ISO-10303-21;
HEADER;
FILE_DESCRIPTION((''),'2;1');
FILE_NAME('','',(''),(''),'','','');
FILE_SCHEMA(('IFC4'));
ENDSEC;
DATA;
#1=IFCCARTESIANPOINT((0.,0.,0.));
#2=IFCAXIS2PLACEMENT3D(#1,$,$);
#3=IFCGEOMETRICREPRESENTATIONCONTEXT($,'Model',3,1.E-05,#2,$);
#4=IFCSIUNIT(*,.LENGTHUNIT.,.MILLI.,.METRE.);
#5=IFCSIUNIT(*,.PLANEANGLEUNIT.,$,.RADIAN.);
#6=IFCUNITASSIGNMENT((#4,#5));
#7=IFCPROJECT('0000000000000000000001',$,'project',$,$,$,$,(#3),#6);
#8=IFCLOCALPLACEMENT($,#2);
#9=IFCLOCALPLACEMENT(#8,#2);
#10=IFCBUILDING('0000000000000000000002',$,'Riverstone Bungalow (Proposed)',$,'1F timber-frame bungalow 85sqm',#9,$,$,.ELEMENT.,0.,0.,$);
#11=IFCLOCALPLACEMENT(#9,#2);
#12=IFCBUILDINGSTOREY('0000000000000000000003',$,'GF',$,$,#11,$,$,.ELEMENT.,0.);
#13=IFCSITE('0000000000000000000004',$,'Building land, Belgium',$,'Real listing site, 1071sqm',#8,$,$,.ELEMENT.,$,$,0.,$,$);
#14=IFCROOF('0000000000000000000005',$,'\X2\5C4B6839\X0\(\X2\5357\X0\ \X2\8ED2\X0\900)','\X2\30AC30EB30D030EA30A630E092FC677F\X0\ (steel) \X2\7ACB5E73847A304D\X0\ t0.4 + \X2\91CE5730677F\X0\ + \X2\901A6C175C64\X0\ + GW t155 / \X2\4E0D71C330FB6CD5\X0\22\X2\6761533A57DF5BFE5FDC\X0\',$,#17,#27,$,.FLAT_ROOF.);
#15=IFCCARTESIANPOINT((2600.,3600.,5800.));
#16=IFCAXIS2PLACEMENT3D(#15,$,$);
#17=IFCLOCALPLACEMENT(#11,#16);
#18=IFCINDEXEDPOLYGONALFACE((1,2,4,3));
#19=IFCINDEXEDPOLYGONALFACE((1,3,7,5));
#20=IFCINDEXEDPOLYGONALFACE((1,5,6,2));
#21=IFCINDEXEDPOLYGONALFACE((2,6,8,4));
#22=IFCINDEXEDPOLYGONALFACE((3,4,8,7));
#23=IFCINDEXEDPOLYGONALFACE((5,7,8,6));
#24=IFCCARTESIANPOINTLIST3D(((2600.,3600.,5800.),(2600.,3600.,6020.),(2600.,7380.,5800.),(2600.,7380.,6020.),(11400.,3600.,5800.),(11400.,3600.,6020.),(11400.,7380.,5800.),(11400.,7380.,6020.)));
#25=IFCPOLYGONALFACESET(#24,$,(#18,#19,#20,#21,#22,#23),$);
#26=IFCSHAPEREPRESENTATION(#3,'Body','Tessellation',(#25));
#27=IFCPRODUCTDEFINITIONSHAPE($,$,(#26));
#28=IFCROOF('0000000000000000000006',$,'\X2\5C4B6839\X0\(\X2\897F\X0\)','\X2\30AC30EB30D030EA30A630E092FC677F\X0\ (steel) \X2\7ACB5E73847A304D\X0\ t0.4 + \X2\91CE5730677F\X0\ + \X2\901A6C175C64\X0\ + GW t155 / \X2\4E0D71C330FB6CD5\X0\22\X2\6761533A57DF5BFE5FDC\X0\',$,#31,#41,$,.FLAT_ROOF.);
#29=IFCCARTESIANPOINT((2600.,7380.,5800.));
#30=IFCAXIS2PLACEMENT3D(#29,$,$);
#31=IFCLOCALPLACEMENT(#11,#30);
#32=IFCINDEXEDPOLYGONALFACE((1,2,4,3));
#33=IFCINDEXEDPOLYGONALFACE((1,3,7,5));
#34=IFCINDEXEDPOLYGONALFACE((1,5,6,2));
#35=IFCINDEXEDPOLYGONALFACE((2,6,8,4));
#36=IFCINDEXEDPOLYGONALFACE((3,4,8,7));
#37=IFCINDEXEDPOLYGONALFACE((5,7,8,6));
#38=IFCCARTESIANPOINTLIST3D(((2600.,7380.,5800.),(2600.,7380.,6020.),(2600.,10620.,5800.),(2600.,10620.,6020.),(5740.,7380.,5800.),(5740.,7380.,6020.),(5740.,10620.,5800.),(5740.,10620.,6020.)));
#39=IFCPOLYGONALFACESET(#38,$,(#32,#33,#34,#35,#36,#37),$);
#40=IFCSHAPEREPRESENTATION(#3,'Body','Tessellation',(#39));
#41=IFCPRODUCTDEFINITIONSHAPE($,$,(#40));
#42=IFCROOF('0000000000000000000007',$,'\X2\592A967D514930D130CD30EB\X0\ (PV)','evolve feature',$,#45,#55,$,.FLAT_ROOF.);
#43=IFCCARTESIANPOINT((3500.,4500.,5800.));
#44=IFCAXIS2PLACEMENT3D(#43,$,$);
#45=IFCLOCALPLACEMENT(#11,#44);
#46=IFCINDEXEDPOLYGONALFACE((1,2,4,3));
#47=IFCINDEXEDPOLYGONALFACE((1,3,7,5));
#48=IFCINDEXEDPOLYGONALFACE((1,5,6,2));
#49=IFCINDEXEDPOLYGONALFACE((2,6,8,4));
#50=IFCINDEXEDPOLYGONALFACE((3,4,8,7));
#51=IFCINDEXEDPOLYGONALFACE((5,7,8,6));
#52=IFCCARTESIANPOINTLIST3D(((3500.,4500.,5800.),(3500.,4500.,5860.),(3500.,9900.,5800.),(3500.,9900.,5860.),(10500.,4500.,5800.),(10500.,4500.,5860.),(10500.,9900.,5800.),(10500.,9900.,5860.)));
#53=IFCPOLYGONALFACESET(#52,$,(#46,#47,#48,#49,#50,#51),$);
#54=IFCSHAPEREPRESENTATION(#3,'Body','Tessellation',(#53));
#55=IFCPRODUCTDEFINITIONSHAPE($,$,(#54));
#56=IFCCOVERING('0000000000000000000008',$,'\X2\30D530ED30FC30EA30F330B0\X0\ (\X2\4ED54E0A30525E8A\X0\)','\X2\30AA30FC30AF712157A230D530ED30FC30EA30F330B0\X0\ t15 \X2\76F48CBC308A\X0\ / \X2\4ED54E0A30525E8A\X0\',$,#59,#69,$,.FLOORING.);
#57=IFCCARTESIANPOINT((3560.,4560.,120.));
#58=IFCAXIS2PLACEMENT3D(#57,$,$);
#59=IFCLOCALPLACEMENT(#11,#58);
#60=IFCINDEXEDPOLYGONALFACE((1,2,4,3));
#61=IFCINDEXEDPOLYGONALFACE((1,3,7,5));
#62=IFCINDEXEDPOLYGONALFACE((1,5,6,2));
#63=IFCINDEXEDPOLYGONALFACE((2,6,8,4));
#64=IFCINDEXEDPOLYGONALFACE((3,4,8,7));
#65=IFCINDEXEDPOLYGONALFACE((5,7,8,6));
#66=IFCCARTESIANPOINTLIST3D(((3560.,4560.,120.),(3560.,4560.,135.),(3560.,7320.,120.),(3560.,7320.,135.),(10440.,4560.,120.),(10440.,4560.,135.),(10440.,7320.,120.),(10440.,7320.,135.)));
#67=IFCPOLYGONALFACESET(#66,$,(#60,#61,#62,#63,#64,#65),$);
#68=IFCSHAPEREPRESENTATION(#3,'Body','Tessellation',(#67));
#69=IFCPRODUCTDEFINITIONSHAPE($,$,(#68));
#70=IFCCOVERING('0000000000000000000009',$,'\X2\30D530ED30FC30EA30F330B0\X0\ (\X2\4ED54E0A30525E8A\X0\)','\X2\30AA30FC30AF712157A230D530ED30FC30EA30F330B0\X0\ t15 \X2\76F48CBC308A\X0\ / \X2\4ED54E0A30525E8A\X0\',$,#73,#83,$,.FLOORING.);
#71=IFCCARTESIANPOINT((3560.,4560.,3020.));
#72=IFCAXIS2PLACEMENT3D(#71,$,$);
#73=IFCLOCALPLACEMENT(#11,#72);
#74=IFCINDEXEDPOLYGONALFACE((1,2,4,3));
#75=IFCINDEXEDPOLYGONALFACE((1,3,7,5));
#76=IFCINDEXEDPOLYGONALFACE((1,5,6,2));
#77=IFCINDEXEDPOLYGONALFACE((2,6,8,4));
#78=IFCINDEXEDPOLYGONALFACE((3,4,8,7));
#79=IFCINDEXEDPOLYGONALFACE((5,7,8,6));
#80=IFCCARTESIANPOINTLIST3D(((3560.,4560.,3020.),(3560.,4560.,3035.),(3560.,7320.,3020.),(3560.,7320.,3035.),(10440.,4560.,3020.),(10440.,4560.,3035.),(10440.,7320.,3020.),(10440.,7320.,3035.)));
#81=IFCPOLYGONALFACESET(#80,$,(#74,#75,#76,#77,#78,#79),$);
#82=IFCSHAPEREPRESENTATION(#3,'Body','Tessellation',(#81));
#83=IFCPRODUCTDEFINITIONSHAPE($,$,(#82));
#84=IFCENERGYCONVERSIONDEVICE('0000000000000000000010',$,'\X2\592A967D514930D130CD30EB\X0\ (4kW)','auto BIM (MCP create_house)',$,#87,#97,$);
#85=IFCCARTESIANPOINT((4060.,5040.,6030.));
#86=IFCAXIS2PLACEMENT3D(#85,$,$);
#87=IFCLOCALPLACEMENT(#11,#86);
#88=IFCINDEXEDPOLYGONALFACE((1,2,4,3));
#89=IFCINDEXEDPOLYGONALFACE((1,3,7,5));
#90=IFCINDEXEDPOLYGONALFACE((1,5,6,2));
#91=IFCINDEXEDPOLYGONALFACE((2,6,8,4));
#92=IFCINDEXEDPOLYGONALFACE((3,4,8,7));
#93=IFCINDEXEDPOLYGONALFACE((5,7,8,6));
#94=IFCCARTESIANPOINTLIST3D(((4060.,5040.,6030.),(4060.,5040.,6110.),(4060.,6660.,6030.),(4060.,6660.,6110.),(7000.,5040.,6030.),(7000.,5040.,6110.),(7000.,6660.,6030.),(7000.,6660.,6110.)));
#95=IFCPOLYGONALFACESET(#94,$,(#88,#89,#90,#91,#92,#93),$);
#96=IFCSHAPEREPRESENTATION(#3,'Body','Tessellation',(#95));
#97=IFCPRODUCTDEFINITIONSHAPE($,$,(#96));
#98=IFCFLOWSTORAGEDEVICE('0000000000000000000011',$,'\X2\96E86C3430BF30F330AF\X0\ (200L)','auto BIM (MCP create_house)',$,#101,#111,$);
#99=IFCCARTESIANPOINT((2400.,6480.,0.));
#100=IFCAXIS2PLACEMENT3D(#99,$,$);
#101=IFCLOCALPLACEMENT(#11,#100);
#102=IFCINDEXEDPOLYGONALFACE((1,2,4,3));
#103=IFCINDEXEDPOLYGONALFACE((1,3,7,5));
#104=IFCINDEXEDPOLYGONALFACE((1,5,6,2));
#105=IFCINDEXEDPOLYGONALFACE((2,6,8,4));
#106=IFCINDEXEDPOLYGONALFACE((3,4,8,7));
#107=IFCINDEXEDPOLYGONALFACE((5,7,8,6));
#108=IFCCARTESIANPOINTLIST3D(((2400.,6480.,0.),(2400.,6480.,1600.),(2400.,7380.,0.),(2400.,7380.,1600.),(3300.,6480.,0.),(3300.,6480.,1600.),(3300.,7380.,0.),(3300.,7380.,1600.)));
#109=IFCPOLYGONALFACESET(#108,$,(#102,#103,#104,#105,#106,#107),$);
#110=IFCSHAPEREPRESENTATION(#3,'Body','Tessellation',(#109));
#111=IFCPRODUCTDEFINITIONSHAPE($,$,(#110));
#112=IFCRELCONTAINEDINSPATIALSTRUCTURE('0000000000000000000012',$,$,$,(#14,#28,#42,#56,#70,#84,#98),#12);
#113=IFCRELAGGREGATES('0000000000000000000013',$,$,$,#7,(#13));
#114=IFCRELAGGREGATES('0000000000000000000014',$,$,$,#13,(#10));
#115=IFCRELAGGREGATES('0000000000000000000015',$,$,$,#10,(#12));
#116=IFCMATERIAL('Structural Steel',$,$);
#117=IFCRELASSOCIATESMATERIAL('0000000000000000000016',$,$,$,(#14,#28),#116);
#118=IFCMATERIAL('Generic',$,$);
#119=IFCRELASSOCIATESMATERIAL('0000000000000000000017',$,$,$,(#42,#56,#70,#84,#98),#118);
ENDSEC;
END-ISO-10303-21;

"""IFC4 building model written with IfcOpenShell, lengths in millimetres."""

from ifc_helpers import new_model, si_unit, frame, frame_2d, origin, place, context, project, spatial, rectangle, extrude, material, element, save


model = new_model("IFC4")

# Units and contexts
model_context = context("Model", 3, precision=1e-05, world=origin())
ifc_project = project(units=[si_unit("LENGTHUNIT", "METRE", prefix="MILLI"), si_unit("PLANEANGLEUNIT", "RADIAN")], contexts=[model_context])

# Site, building, storey
site_placement = place(None, origin())
site = spatial("IfcSite", under=ifc_project, at=site_placement, Name="Building land, Belgium", ObjectType="Real listing site, 1071sqm", CompositionType="ELEMENT", RefElevation=0.0)
building_placement = place(site_placement, origin())
building = spatial("IfcBuilding", under=site, at=building_placement, Name="Riverstone Bungalow (Proposed)", ObjectType="1F timber-frame bungalow 85sqm", CompositionType="ELEMENT", ElevationOfRefHeight=0.0, ElevationOfTerrain=0.0)
storey_placement = place(building_placement, origin())
storey = spatial("IfcBuildingStorey", under=building, at=storey_placement, Name="GF", CompositionType="ELEMENT", Elevation=0.0)

# Shared definitions
ifc_material_1 = material(Name="Generic")

# Roofs
ifc_material_2 = material(Name="Structural Steel")
roof_1_placement = place(storey_placement, frame((2600.0, 3600.0, 5800.0)))
element("IfcRoof", 1, at=roof_1_placement, inside=storey, material=ifc_material_2, Name="屋根(南 軒900)", Description="ガルバリウム鋼板 (steel) 立平葺き t0.4 + 野地板 + 通気層 + GW t155 / 不燃・法22条区域対応", PredefinedType="FLAT_ROOF", context=model_context, shape_type="SweptSolid", body=[
    extrude(rectangle(XDim=8800.0, YDim=3780.0, at=frame_2d((4400.0, 1890.0))), frame((2600.0, 3600.0, 5800.0)), (0.0, 0.0, 1.0), 220.0),
])
roof_2_placement = place(storey_placement, frame((2600.0, 7380.0, 5800.0)))
element("IfcRoof", 2, at=roof_2_placement, inside=storey, material=ifc_material_2, Name="屋根(西)", Description="ガルバリウム鋼板 (steel) 立平葺き t0.4 + 野地板 + 通気層 + GW t155 / 不燃・法22条区域対応", PredefinedType="FLAT_ROOF", context=model_context, shape_type="SweptSolid", body=[
    extrude(rectangle(XDim=3140.0, YDim=3240.0, at=frame_2d((1570.0, 1620.0))), frame((2600.0, 7380.0, 5800.0)), (0.0, 0.0, 1.0), 220.0),
])
roof_3_placement = place(storey_placement, frame((3500.0, 4500.0, 5800.0)))
element("IfcRoof", 3, at=roof_3_placement, inside=storey, material=ifc_material_1, Name="太陽光パネル (PV)", Description="evolve feature", PredefinedType="FLAT_ROOF", context=model_context, shape_type="SweptSolid", body=[
    extrude(rectangle(XDim=7000.0, YDim=5400.0, at=frame_2d((3500.0, 2700.0))), frame((3500.0, 4500.0, 5800.0)), (0.0, 0.0, 1.0), 60.0),
])

# Coverings
covering_1_placement = place(storey_placement, frame((3560.0, 4560.0, 120.0)))
element("IfcCovering", 4, at=covering_1_placement, inside=storey, material=ifc_material_1, Name="フローリング (仕上げ床)", Description="オーク無垢フローリング t15 直貼り / 仕上げ床", PredefinedType="FLOORING", context=model_context, shape_type="SweptSolid", body=[
    extrude(rectangle(XDim=6880.0, YDim=2760.0, at=frame_2d((3440.0, 1380.0))), frame((3560.0, 4560.0, 120.0)), (0.0, 0.0, 1.0), 15.0),
])
covering_2_placement = place(storey_placement, frame((3560.0, 4560.0, 3020.0)))
element("IfcCovering", 5, at=covering_2_placement, inside=storey, material=ifc_material_1, Name="フローリング (仕上げ床)", Description="オーク無垢フローリング t15 直貼り / 仕上げ床", PredefinedType="FLOORING", context=model_context, shape_type="SweptSolid", body=[
    extrude(rectangle(XDim=6880.0, YDim=2760.0, at=frame_2d((3440.0, 1380.0))), frame((3560.0, 4560.0, 3020.0)), (0.0, 0.0, 1.0), 15.0),
])

# Energy conversion device
energy_conversion_device_placement = place(storey_placement, frame((4060.0, 5040.0, 6030.0)))
element("IfcEnergyConversionDevice", 6, at=energy_conversion_device_placement, inside=storey, material=ifc_material_1, Name="太陽光パネル (4kW)", Description="auto BIM (MCP create_house)", context=model_context, shape_type="SweptSolid", body=[
    extrude(rectangle(XDim=2940.0, YDim=1620.0, at=frame_2d((1470.0, 810.0))), frame((4060.0, 5040.0, 6030.0)), (0.0, 0.0, 1.0), 80.0),
])

# Flow storage device
flow_storage_device_placement = place(storey_placement, frame((2400.0, 6480.0, 0.0)))
element("IfcFlowStorageDevice", 7, at=flow_storage_device_placement, inside=storey, material=ifc_material_1, Name="雨水タンク (200L)", Description="auto BIM (MCP create_house)", context=model_context, shape_type="SweptSolid", body=[
    extrude(rectangle(XDim=900.0, YDim=900.0, at=frame_2d((450.0, 450.0))), frame((2400.0, 6480.0, 0.0)), (0.0, 0.0, 1.0), 1600.0),
])

save(model, "model.ifc")
